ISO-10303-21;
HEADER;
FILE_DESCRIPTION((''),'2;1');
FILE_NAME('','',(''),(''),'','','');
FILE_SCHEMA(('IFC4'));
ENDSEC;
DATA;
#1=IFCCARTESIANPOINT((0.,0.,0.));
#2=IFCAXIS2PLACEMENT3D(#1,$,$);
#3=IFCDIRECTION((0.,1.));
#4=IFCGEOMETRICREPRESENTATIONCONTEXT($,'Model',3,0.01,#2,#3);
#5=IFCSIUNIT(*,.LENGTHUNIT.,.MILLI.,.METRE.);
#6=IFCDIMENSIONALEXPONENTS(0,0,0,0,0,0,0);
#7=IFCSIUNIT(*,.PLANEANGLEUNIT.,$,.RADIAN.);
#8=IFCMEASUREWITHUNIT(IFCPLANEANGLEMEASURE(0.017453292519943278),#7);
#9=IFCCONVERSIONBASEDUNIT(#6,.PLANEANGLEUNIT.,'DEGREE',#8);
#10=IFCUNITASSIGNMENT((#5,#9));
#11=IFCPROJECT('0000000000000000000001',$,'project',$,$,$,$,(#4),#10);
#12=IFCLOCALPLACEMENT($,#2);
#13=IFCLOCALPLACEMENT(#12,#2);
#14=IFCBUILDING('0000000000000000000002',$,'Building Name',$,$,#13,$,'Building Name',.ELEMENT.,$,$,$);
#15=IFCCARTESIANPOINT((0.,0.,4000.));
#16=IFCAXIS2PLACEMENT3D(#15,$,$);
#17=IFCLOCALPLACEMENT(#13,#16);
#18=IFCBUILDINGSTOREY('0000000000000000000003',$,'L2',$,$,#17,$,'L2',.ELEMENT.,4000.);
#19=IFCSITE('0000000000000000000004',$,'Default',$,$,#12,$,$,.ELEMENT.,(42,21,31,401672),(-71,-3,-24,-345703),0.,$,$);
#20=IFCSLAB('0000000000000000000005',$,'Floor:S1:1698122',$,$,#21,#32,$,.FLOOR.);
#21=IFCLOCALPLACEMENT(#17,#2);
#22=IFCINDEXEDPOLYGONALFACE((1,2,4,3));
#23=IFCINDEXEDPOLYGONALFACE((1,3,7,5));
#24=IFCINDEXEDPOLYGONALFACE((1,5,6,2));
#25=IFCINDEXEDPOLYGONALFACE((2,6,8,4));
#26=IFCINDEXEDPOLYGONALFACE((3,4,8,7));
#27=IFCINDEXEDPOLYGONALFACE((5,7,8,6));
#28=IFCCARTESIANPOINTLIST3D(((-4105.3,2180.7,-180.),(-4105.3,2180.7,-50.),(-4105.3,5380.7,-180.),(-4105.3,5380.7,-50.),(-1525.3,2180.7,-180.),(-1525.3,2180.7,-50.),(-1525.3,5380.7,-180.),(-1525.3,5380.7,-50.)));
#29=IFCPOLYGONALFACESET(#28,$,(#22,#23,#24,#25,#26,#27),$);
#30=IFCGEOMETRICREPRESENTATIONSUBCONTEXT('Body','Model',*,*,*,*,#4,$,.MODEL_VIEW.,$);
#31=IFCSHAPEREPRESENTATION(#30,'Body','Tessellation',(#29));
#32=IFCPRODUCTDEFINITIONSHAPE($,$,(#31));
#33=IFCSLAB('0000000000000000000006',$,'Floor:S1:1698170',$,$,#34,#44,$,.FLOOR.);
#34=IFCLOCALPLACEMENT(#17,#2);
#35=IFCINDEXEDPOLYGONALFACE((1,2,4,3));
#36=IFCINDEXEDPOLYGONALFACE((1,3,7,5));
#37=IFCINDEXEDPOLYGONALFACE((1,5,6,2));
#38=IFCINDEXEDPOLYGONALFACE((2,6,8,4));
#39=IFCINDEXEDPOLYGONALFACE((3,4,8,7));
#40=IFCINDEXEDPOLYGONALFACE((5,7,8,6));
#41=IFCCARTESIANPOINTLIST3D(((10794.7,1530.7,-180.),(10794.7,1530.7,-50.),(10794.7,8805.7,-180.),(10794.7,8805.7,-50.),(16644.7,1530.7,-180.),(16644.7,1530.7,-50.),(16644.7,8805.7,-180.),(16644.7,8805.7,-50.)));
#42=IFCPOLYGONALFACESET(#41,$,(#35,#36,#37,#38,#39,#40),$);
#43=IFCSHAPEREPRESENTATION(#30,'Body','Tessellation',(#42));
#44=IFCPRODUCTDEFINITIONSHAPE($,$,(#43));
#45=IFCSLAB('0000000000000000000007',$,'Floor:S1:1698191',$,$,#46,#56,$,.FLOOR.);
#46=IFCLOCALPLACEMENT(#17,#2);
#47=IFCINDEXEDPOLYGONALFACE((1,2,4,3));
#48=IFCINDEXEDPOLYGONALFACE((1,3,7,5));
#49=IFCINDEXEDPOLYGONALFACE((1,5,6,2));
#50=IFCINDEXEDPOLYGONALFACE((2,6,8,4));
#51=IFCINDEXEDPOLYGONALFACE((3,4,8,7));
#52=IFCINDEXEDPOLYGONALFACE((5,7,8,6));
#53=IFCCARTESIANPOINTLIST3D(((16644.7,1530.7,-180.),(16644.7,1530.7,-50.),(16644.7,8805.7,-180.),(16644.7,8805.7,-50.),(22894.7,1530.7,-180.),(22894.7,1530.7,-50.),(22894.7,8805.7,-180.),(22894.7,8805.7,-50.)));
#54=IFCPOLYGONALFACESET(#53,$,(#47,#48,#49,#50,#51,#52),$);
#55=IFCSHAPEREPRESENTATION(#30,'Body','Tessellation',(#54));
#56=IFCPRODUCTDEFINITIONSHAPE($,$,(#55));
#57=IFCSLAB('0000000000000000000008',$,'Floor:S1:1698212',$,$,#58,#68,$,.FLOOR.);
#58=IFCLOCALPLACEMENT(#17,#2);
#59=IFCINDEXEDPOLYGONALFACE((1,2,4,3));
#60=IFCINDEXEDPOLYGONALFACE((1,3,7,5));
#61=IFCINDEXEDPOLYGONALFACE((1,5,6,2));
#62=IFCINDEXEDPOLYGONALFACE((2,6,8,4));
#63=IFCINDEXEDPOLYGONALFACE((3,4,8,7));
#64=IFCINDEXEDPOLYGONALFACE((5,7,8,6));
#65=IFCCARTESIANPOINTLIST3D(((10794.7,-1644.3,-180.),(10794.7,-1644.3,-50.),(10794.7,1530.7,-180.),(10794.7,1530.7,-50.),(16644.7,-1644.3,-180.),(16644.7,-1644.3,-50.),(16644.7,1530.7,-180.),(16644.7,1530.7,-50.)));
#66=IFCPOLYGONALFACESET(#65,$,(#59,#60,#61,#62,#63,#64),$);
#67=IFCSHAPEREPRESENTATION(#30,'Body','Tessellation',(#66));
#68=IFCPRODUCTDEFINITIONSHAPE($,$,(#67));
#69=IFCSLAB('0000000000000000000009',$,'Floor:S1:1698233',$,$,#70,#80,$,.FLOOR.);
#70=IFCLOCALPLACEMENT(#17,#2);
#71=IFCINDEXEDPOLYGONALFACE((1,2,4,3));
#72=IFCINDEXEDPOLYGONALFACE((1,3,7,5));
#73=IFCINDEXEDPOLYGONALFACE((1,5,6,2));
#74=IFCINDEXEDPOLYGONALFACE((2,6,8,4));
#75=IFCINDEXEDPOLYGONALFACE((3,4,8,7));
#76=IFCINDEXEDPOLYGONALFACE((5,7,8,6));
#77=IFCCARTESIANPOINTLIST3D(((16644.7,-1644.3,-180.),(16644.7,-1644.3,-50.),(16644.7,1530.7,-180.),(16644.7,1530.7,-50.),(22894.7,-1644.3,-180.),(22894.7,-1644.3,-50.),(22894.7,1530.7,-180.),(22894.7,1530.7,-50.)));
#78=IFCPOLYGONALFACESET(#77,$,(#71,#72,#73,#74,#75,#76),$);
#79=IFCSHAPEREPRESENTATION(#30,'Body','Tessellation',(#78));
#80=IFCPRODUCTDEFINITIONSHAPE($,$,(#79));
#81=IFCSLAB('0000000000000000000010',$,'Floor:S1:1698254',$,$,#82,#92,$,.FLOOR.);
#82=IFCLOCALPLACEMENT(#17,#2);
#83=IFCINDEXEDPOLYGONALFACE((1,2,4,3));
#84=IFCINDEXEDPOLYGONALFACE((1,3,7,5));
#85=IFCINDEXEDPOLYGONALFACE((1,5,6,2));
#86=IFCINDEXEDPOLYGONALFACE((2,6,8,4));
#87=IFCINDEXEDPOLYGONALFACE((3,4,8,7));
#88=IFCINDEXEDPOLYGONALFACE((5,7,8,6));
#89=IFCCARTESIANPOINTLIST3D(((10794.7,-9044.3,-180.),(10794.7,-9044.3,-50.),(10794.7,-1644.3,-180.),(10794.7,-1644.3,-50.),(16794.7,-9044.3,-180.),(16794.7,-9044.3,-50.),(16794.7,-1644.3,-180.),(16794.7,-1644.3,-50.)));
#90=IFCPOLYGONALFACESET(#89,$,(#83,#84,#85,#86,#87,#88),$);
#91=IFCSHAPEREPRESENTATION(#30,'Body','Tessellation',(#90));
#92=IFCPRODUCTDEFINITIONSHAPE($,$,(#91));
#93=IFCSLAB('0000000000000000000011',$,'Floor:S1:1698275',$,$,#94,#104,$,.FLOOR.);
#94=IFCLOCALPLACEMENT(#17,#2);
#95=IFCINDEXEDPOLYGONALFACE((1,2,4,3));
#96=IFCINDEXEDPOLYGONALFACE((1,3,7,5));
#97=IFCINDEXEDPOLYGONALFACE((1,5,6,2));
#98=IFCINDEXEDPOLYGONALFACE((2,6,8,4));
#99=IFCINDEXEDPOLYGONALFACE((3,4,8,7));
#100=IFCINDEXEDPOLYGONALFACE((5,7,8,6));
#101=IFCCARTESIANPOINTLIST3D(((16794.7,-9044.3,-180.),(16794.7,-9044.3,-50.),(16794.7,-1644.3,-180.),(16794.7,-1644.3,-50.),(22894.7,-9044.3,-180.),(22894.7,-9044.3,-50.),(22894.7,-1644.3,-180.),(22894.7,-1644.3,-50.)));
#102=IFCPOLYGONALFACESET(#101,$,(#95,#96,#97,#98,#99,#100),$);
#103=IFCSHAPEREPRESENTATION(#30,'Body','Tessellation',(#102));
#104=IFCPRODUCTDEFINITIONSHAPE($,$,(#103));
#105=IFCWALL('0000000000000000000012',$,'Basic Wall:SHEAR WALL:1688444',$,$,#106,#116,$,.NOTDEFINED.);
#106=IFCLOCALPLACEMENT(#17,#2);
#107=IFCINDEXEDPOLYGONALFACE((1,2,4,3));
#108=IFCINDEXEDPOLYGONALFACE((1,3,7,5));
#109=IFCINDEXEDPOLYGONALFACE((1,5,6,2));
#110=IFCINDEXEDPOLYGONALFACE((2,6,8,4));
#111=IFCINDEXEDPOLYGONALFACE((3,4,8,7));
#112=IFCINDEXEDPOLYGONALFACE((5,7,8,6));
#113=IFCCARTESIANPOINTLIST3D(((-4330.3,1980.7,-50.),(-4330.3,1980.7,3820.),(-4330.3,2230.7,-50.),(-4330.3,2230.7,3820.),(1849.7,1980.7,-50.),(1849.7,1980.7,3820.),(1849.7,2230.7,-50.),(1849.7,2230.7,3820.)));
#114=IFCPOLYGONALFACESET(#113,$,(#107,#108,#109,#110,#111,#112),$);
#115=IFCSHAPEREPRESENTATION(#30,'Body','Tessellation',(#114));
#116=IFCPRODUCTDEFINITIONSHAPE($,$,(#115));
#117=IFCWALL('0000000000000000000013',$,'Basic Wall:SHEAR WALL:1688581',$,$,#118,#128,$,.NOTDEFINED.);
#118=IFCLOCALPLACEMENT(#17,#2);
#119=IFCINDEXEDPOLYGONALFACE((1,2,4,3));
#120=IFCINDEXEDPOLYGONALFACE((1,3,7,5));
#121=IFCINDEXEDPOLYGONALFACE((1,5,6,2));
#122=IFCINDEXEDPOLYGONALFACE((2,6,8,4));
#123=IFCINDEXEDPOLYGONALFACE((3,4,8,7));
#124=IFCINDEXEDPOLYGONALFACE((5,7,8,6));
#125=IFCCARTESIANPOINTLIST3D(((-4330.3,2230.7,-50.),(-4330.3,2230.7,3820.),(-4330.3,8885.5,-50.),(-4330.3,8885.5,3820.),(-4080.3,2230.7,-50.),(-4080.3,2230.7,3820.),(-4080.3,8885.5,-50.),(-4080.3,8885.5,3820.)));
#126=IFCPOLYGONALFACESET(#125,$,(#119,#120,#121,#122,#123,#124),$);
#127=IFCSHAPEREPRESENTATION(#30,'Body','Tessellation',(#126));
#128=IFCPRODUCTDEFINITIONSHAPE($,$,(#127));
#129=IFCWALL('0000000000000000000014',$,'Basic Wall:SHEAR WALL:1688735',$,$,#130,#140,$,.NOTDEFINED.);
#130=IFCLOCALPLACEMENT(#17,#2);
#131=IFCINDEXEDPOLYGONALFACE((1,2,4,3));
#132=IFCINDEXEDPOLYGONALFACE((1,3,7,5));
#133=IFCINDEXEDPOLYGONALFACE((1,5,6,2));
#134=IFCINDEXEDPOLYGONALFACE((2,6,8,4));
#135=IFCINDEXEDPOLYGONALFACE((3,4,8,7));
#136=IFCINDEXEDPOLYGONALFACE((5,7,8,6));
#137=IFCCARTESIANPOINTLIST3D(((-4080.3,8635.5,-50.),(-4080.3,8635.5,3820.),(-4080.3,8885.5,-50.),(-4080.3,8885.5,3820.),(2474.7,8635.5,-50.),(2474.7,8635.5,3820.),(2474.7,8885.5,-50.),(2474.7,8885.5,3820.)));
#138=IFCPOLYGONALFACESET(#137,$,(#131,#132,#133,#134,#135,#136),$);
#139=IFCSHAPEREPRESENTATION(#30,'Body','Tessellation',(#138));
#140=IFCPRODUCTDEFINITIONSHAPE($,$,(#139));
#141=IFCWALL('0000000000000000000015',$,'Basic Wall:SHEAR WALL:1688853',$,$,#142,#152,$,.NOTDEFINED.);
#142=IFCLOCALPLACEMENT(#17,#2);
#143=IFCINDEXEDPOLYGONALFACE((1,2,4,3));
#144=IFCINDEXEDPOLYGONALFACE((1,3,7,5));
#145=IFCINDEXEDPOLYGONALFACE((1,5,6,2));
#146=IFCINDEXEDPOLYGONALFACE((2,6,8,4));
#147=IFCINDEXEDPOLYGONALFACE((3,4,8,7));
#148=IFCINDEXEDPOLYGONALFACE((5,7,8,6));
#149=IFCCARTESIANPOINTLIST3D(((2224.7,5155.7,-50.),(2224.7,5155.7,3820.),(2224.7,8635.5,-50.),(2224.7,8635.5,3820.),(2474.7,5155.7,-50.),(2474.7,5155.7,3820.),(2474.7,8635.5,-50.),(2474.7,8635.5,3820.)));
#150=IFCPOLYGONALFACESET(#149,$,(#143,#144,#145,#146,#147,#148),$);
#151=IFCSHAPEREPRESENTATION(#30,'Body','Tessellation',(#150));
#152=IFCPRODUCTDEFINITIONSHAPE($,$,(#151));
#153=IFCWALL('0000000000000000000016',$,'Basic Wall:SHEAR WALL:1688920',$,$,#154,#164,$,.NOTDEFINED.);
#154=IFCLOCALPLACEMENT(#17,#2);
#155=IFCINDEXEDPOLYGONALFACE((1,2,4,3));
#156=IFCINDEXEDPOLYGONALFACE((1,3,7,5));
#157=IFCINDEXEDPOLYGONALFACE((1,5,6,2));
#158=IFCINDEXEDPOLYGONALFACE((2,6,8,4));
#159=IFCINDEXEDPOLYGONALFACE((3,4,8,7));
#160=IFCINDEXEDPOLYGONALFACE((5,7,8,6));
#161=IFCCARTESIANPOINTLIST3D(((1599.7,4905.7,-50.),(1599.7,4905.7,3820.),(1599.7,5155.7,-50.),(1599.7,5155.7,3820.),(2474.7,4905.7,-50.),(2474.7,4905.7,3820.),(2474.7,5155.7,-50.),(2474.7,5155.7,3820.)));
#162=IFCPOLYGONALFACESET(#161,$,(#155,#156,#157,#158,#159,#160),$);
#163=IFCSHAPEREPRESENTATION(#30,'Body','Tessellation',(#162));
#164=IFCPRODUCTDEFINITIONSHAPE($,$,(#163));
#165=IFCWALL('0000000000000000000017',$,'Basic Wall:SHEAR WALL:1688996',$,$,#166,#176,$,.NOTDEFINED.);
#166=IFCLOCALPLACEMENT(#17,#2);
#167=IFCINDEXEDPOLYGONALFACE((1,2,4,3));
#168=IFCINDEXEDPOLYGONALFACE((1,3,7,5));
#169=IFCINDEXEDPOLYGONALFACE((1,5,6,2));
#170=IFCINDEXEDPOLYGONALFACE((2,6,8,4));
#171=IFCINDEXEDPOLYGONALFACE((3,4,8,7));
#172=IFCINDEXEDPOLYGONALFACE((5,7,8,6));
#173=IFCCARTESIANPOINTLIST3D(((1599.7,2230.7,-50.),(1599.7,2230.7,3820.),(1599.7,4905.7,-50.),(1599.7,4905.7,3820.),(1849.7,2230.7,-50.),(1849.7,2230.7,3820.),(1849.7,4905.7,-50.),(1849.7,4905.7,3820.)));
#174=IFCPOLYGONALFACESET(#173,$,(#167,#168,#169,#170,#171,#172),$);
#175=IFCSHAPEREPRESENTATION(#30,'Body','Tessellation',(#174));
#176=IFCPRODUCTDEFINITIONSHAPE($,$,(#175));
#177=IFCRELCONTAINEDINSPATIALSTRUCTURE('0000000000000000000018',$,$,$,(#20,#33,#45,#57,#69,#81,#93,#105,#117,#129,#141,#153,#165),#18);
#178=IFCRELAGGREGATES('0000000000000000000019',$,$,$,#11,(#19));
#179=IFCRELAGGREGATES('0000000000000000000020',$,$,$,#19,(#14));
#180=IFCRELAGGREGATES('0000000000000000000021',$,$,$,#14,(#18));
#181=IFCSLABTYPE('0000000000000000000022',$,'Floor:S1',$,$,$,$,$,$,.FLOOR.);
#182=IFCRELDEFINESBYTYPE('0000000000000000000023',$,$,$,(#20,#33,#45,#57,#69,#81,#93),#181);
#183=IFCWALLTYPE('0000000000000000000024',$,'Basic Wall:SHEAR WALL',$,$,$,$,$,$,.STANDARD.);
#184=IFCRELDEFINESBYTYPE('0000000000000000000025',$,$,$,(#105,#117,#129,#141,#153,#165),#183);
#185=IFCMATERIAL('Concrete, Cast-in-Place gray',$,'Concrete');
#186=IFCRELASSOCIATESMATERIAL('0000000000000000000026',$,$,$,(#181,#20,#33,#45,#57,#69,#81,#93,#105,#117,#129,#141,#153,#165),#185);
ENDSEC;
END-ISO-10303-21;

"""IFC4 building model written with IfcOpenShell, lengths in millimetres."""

from ifc_helpers import new_model, entity, si_unit, converted_unit, direction, frame, origin, place, context, subcontext, project, spatial, indexed_curve, outline, extrude, material, type_object, element, save


model = new_model("IFC4")

# Units and contexts
model_context = context("Model", 3, precision=0.01, world=origin(), true_north=direction((0.0, 1.0)))
body_context = subcontext(model_context, "Body", "Model", "MODEL_VIEW")
ifc_project = project(units=[si_unit("LENGTHUNIT", "METRE", prefix="MILLI"), converted_unit("PLANEANGLEUNIT", "DEGREE", entity("IfcPlaneAngleMeasure", 0.017453292519943278), si_unit("PLANEANGLEUNIT", "RADIAN"), dimensions=[0, 0, 0, 0, 0, 0, 0])], contexts=[model_context])

# Site, building, storey
site_placement = place(None, origin())
site = spatial("IfcSite", under=ifc_project, at=site_placement, Name="Default", CompositionType="ELEMENT", RefLatitude=(42, 21, 31, 401672), RefLongitude=(-71, -3, -24, -345703), RefElevation=0.0)
building_placement = place(site_placement, origin())
building = spatial("IfcBuilding", under=site, at=building_placement, Name="Building Name", LongName="Building Name", CompositionType="ELEMENT")
storey_placement = place(building_placement, frame((0.0, 0.0, 4000.0)))
storey = spatial("IfcBuildingStorey", under=building, at=storey_placement, Name="L2", LongName="L2", CompositionType="ELEMENT", Elevation=4000.0)

# Shared definitions
ifc_material = material(Name="Concrete, Cast-in-Place gray", Category="Concrete")

# Slabs
slab_type = type_object("IfcSlabType", Name="Floor:S1", PredefinedType="FLOOR", material=ifc_material)
slab_1_placement = place(storey_placement, origin())
element("IfcSlab", 1, at=slab_1_placement, inside=storey, type_object=slab_type, material=ifc_material, Name="Floor:S1:1698122", PredefinedType="FLOOR", context=body_context, shape_type="SweptSolid", body=[
    extrude(outline(indexed_curve([(-1600.0, -1290.0), (1600.0, -1290.0), (1600.0, 1290.0), (-1600.0, 1290.0), (-1600.0, -1290.0)], self_intersect=False)), frame((-2815.3, 3780.7, -50.0), z_axis=(0.0, 0.0, -1.0), x_axis=(0.0, 1.0, 0.0)), (0.0, 0.0, 1.0), 130.0),
])
slab_2_placement = place(storey_placement, origin())
element("IfcSlab", 2, at=slab_2_placement, inside=storey, type_object=slab_type, material=ifc_material, Name="Floor:S1:1698170", PredefinedType="FLOOR", context=body_context, shape_type="SweptSolid", body=[
    extrude(outline(indexed_curve([(-3637.5, -2925.0), (3637.5, -2925.0), (3637.5, 2925.0), (-3637.5, 2925.0), (-3637.5, -2925.0)], self_intersect=False)), frame((13719.7, 5168.2, -50.0), z_axis=(0.0, 0.0, -1.0), x_axis=(0.0, 1.0, 0.0)), (0.0, 0.0, 1.0), 130.0),
])
slab_3_placement = place(storey_placement, origin())
element("IfcSlab", 3, at=slab_3_placement, inside=storey, type_object=slab_type, material=ifc_material, Name="Floor:S1:1698191", PredefinedType="FLOOR", context=body_context, shape_type="SweptSolid", body=[
    extrude(outline(indexed_curve([(-3637.5, -3125.0), (3637.5, -3125.0), (3637.5, 3125.0), (-3637.5, 3125.0), (-3637.5, -3125.0)], self_intersect=False)), frame((19769.7, 5168.2, -50.0), z_axis=(0.0, 0.0, -1.0), x_axis=(0.0, 1.0, 0.0)), (0.0, 0.0, 1.0), 130.0),
])
slab_4_placement = place(storey_placement, origin())
element("IfcSlab", 4, at=slab_4_placement, inside=storey, type_object=slab_type, material=ifc_material, Name="Floor:S1:1698212", PredefinedType="FLOOR", context=body_context, shape_type="SweptSolid", body=[
    extrude(outline(indexed_curve([(-1587.5, -2925.0), (1587.5, -2925.0), (1587.5, 2925.0), (-1587.5, 2925.0), (-1587.5, -2925.0)], self_intersect=False)), frame((13719.7, -56.8, -50.0), z_axis=(0.0, 0.0, -1.0), x_axis=(0.0, 1.0, 0.0)), (0.0, 0.0, 1.0), 130.0),
])
slab_5_placement = place(storey_placement, origin())
element("IfcSlab", 5, at=slab_5_placement, inside=storey, type_object=slab_type, material=ifc_material, Name="Floor:S1:1698233", PredefinedType="FLOOR", context=body_context, shape_type="SweptSolid", body=[
    extrude(outline(indexed_curve([(-1587.5, -3125.0), (1587.5, -3125.0), (1587.5, 3125.0), (-1587.5, 3125.0), (-1587.5, -3125.0)], self_intersect=False)), frame((19769.7, -56.8, -50.0), z_axis=(0.0, 0.0, -1.0), x_axis=(0.0, 1.0, 0.0)), (0.0, 0.0, 1.0), 130.0),
])
slab_6_placement = place(storey_placement, origin())
element("IfcSlab", 6, at=slab_6_placement, inside=storey, type_object=slab_type, material=ifc_material, Name="Floor:S1:1698254", PredefinedType="FLOOR", context=body_context, shape_type="SweptSolid", body=[
    extrude(outline(indexed_curve([(-3700.0, -3000.0), (3700.0, -3000.0), (3700.0, 3000.0), (-3700.0, 3000.0), (-3700.0, -3000.0)], self_intersect=False)), frame((13794.7, -5344.3, -50.0), z_axis=(0.0, 0.0, -1.0), x_axis=(0.0, 1.0, 0.0)), (0.0, 0.0, 1.0), 130.0),
])
slab_7_placement = place(storey_placement, origin())
element("IfcSlab", 7, at=slab_7_placement, inside=storey, type_object=slab_type, material=ifc_material, Name="Floor:S1:1698275", PredefinedType="FLOOR", context=body_context, shape_type="SweptSolid", body=[
    extrude(outline(indexed_curve([(-3700.0, -3050.0), (3700.0, -3050.0), (3700.0, 3050.0), (-3700.0, 3050.0), (-3700.0, -3050.0)], self_intersect=False)), frame((19844.7, -5344.3, -50.0), z_axis=(0.0, 0.0, -1.0), x_axis=(0.0, 1.0, 0.0)), (0.0, 0.0, 1.0), 130.0),
])

# Walls
wall_type = type_object("IfcWallType", Name="Basic Wall:SHEAR WALL", PredefinedType="STANDARD")
wall_1_placement = place(storey_placement, frame((-4330.3, 2105.7, -50.0)))
element("IfcWall", 8, at=wall_1_placement, inside=storey, type_object=wall_type, material=ifc_material, Name="Basic Wall:SHEAR WALL:1688444", PredefinedType="NOTDEFINED", context=body_context, shape_type="SweptSolid", body=[
    extrude(outline(indexed_curve([(6180.0, 125.0), (0.0, 125.0), (0.0, -125.0), (6180.0, -125.0), (6180.0, 125.0)], self_intersect=False)), origin(), (0.0, 0.0, 1.0), 3870.0),
])
wall_2_placement = place(storey_placement, frame((-4205.3, 2230.7, -50.0), z_axis=(0.0, 0.0, 1.0), x_axis=(0.0, 1.0, 0.0)))
element("IfcWall", 9, at=wall_2_placement, inside=storey, type_object=wall_type, material=ifc_material, Name="Basic Wall:SHEAR WALL:1688581", PredefinedType="NOTDEFINED", context=body_context, shape_type="SweptSolid", body=[
    extrude(outline(indexed_curve([(6654.9, 125.0), (0.0, 125.0), (0.0, -125.0), (6654.9, -125.0), (6654.9, 125.0)], self_intersect=False)), origin(), (0.0, 0.0, 1.0), 3870.0),
])
wall_3_placement = place(storey_placement, frame((-4080.3, 8760.5, -50.0)))
element("IfcWall", 10, at=wall_3_placement, inside=storey, type_object=wall_type, material=ifc_material, Name="Basic Wall:SHEAR WALL:1688735", PredefinedType="NOTDEFINED", context=body_context, shape_type="SweptSolid", body=[
    extrude(outline(indexed_curve([(6555.0, 125.0), (0.0, 125.0), (0.0, -125.0), (6555.0, -125.0), (6555.0, 125.0)], self_intersect=False)), origin(), (0.0, 0.0, 1.0), 3870.0),
])
wall_4_placement = place(storey_placement, frame((2349.7, 8635.5, -50.0), z_axis=(0.0, 0.0, 1.0), x_axis=(0.0, -1.0, 0.0)))
element("IfcWall", 11, at=wall_4_placement, inside=storey, type_object=wall_type, material=ifc_material, Name="Basic Wall:SHEAR WALL:1688853", PredefinedType="NOTDEFINED", context=body_context, shape_type="SweptSolid", body=[
    extrude(outline(indexed_curve([(3479.9, 125.0), (0.0, 125.0), (0.0, -125.0), (3479.9, -125.0), (3479.9, 125.0)], self_intersect=False)), origin(), (0.0, 0.0, 1.0), 3870.0),
])
wall_5_placement = place(storey_placement, frame((2474.7, 5030.7, -50.0), z_axis=(0.0, 0.0, 1.0), x_axis=(-1.0, 0.0, 0.0)))
element("IfcWall", 12, at=wall_5_placement, inside=storey, type_object=wall_type, material=ifc_material, Name="Basic Wall:SHEAR WALL:1688920", PredefinedType="NOTDEFINED", context=body_context, shape_type="SweptSolid", body=[
    extrude(outline(indexed_curve([(875.0, 125.0), (0.0, 125.0), (0.0, -125.0), (875.0, -125.0), (875.0, 125.0)], self_intersect=False)), origin(), (0.0, 0.0, 1.0), 3870.0),
])
wall_6_placement = place(storey_placement, frame((1724.7, 4905.7, -50.0), z_axis=(0.0, 0.0, 1.0), x_axis=(0.0, -1.0, 0.0)))
element("IfcWall", 13, at=wall_6_placement, inside=storey, type_object=wall_type, material=ifc_material, Name="Basic Wall:SHEAR WALL:1688996", PredefinedType="NOTDEFINED", context=body_context, shape_type="SweptSolid", body=[
    extrude(outline(indexed_curve([(2675.0, 125.0), (0.0, 125.0), (0.0, -125.0), (2675.0, -125.0), (2675.0, 125.0)], self_intersect=False)), origin(), (0.0, 0.0, 1.0), 3870.0),
])

save(model, "model.ifc")
